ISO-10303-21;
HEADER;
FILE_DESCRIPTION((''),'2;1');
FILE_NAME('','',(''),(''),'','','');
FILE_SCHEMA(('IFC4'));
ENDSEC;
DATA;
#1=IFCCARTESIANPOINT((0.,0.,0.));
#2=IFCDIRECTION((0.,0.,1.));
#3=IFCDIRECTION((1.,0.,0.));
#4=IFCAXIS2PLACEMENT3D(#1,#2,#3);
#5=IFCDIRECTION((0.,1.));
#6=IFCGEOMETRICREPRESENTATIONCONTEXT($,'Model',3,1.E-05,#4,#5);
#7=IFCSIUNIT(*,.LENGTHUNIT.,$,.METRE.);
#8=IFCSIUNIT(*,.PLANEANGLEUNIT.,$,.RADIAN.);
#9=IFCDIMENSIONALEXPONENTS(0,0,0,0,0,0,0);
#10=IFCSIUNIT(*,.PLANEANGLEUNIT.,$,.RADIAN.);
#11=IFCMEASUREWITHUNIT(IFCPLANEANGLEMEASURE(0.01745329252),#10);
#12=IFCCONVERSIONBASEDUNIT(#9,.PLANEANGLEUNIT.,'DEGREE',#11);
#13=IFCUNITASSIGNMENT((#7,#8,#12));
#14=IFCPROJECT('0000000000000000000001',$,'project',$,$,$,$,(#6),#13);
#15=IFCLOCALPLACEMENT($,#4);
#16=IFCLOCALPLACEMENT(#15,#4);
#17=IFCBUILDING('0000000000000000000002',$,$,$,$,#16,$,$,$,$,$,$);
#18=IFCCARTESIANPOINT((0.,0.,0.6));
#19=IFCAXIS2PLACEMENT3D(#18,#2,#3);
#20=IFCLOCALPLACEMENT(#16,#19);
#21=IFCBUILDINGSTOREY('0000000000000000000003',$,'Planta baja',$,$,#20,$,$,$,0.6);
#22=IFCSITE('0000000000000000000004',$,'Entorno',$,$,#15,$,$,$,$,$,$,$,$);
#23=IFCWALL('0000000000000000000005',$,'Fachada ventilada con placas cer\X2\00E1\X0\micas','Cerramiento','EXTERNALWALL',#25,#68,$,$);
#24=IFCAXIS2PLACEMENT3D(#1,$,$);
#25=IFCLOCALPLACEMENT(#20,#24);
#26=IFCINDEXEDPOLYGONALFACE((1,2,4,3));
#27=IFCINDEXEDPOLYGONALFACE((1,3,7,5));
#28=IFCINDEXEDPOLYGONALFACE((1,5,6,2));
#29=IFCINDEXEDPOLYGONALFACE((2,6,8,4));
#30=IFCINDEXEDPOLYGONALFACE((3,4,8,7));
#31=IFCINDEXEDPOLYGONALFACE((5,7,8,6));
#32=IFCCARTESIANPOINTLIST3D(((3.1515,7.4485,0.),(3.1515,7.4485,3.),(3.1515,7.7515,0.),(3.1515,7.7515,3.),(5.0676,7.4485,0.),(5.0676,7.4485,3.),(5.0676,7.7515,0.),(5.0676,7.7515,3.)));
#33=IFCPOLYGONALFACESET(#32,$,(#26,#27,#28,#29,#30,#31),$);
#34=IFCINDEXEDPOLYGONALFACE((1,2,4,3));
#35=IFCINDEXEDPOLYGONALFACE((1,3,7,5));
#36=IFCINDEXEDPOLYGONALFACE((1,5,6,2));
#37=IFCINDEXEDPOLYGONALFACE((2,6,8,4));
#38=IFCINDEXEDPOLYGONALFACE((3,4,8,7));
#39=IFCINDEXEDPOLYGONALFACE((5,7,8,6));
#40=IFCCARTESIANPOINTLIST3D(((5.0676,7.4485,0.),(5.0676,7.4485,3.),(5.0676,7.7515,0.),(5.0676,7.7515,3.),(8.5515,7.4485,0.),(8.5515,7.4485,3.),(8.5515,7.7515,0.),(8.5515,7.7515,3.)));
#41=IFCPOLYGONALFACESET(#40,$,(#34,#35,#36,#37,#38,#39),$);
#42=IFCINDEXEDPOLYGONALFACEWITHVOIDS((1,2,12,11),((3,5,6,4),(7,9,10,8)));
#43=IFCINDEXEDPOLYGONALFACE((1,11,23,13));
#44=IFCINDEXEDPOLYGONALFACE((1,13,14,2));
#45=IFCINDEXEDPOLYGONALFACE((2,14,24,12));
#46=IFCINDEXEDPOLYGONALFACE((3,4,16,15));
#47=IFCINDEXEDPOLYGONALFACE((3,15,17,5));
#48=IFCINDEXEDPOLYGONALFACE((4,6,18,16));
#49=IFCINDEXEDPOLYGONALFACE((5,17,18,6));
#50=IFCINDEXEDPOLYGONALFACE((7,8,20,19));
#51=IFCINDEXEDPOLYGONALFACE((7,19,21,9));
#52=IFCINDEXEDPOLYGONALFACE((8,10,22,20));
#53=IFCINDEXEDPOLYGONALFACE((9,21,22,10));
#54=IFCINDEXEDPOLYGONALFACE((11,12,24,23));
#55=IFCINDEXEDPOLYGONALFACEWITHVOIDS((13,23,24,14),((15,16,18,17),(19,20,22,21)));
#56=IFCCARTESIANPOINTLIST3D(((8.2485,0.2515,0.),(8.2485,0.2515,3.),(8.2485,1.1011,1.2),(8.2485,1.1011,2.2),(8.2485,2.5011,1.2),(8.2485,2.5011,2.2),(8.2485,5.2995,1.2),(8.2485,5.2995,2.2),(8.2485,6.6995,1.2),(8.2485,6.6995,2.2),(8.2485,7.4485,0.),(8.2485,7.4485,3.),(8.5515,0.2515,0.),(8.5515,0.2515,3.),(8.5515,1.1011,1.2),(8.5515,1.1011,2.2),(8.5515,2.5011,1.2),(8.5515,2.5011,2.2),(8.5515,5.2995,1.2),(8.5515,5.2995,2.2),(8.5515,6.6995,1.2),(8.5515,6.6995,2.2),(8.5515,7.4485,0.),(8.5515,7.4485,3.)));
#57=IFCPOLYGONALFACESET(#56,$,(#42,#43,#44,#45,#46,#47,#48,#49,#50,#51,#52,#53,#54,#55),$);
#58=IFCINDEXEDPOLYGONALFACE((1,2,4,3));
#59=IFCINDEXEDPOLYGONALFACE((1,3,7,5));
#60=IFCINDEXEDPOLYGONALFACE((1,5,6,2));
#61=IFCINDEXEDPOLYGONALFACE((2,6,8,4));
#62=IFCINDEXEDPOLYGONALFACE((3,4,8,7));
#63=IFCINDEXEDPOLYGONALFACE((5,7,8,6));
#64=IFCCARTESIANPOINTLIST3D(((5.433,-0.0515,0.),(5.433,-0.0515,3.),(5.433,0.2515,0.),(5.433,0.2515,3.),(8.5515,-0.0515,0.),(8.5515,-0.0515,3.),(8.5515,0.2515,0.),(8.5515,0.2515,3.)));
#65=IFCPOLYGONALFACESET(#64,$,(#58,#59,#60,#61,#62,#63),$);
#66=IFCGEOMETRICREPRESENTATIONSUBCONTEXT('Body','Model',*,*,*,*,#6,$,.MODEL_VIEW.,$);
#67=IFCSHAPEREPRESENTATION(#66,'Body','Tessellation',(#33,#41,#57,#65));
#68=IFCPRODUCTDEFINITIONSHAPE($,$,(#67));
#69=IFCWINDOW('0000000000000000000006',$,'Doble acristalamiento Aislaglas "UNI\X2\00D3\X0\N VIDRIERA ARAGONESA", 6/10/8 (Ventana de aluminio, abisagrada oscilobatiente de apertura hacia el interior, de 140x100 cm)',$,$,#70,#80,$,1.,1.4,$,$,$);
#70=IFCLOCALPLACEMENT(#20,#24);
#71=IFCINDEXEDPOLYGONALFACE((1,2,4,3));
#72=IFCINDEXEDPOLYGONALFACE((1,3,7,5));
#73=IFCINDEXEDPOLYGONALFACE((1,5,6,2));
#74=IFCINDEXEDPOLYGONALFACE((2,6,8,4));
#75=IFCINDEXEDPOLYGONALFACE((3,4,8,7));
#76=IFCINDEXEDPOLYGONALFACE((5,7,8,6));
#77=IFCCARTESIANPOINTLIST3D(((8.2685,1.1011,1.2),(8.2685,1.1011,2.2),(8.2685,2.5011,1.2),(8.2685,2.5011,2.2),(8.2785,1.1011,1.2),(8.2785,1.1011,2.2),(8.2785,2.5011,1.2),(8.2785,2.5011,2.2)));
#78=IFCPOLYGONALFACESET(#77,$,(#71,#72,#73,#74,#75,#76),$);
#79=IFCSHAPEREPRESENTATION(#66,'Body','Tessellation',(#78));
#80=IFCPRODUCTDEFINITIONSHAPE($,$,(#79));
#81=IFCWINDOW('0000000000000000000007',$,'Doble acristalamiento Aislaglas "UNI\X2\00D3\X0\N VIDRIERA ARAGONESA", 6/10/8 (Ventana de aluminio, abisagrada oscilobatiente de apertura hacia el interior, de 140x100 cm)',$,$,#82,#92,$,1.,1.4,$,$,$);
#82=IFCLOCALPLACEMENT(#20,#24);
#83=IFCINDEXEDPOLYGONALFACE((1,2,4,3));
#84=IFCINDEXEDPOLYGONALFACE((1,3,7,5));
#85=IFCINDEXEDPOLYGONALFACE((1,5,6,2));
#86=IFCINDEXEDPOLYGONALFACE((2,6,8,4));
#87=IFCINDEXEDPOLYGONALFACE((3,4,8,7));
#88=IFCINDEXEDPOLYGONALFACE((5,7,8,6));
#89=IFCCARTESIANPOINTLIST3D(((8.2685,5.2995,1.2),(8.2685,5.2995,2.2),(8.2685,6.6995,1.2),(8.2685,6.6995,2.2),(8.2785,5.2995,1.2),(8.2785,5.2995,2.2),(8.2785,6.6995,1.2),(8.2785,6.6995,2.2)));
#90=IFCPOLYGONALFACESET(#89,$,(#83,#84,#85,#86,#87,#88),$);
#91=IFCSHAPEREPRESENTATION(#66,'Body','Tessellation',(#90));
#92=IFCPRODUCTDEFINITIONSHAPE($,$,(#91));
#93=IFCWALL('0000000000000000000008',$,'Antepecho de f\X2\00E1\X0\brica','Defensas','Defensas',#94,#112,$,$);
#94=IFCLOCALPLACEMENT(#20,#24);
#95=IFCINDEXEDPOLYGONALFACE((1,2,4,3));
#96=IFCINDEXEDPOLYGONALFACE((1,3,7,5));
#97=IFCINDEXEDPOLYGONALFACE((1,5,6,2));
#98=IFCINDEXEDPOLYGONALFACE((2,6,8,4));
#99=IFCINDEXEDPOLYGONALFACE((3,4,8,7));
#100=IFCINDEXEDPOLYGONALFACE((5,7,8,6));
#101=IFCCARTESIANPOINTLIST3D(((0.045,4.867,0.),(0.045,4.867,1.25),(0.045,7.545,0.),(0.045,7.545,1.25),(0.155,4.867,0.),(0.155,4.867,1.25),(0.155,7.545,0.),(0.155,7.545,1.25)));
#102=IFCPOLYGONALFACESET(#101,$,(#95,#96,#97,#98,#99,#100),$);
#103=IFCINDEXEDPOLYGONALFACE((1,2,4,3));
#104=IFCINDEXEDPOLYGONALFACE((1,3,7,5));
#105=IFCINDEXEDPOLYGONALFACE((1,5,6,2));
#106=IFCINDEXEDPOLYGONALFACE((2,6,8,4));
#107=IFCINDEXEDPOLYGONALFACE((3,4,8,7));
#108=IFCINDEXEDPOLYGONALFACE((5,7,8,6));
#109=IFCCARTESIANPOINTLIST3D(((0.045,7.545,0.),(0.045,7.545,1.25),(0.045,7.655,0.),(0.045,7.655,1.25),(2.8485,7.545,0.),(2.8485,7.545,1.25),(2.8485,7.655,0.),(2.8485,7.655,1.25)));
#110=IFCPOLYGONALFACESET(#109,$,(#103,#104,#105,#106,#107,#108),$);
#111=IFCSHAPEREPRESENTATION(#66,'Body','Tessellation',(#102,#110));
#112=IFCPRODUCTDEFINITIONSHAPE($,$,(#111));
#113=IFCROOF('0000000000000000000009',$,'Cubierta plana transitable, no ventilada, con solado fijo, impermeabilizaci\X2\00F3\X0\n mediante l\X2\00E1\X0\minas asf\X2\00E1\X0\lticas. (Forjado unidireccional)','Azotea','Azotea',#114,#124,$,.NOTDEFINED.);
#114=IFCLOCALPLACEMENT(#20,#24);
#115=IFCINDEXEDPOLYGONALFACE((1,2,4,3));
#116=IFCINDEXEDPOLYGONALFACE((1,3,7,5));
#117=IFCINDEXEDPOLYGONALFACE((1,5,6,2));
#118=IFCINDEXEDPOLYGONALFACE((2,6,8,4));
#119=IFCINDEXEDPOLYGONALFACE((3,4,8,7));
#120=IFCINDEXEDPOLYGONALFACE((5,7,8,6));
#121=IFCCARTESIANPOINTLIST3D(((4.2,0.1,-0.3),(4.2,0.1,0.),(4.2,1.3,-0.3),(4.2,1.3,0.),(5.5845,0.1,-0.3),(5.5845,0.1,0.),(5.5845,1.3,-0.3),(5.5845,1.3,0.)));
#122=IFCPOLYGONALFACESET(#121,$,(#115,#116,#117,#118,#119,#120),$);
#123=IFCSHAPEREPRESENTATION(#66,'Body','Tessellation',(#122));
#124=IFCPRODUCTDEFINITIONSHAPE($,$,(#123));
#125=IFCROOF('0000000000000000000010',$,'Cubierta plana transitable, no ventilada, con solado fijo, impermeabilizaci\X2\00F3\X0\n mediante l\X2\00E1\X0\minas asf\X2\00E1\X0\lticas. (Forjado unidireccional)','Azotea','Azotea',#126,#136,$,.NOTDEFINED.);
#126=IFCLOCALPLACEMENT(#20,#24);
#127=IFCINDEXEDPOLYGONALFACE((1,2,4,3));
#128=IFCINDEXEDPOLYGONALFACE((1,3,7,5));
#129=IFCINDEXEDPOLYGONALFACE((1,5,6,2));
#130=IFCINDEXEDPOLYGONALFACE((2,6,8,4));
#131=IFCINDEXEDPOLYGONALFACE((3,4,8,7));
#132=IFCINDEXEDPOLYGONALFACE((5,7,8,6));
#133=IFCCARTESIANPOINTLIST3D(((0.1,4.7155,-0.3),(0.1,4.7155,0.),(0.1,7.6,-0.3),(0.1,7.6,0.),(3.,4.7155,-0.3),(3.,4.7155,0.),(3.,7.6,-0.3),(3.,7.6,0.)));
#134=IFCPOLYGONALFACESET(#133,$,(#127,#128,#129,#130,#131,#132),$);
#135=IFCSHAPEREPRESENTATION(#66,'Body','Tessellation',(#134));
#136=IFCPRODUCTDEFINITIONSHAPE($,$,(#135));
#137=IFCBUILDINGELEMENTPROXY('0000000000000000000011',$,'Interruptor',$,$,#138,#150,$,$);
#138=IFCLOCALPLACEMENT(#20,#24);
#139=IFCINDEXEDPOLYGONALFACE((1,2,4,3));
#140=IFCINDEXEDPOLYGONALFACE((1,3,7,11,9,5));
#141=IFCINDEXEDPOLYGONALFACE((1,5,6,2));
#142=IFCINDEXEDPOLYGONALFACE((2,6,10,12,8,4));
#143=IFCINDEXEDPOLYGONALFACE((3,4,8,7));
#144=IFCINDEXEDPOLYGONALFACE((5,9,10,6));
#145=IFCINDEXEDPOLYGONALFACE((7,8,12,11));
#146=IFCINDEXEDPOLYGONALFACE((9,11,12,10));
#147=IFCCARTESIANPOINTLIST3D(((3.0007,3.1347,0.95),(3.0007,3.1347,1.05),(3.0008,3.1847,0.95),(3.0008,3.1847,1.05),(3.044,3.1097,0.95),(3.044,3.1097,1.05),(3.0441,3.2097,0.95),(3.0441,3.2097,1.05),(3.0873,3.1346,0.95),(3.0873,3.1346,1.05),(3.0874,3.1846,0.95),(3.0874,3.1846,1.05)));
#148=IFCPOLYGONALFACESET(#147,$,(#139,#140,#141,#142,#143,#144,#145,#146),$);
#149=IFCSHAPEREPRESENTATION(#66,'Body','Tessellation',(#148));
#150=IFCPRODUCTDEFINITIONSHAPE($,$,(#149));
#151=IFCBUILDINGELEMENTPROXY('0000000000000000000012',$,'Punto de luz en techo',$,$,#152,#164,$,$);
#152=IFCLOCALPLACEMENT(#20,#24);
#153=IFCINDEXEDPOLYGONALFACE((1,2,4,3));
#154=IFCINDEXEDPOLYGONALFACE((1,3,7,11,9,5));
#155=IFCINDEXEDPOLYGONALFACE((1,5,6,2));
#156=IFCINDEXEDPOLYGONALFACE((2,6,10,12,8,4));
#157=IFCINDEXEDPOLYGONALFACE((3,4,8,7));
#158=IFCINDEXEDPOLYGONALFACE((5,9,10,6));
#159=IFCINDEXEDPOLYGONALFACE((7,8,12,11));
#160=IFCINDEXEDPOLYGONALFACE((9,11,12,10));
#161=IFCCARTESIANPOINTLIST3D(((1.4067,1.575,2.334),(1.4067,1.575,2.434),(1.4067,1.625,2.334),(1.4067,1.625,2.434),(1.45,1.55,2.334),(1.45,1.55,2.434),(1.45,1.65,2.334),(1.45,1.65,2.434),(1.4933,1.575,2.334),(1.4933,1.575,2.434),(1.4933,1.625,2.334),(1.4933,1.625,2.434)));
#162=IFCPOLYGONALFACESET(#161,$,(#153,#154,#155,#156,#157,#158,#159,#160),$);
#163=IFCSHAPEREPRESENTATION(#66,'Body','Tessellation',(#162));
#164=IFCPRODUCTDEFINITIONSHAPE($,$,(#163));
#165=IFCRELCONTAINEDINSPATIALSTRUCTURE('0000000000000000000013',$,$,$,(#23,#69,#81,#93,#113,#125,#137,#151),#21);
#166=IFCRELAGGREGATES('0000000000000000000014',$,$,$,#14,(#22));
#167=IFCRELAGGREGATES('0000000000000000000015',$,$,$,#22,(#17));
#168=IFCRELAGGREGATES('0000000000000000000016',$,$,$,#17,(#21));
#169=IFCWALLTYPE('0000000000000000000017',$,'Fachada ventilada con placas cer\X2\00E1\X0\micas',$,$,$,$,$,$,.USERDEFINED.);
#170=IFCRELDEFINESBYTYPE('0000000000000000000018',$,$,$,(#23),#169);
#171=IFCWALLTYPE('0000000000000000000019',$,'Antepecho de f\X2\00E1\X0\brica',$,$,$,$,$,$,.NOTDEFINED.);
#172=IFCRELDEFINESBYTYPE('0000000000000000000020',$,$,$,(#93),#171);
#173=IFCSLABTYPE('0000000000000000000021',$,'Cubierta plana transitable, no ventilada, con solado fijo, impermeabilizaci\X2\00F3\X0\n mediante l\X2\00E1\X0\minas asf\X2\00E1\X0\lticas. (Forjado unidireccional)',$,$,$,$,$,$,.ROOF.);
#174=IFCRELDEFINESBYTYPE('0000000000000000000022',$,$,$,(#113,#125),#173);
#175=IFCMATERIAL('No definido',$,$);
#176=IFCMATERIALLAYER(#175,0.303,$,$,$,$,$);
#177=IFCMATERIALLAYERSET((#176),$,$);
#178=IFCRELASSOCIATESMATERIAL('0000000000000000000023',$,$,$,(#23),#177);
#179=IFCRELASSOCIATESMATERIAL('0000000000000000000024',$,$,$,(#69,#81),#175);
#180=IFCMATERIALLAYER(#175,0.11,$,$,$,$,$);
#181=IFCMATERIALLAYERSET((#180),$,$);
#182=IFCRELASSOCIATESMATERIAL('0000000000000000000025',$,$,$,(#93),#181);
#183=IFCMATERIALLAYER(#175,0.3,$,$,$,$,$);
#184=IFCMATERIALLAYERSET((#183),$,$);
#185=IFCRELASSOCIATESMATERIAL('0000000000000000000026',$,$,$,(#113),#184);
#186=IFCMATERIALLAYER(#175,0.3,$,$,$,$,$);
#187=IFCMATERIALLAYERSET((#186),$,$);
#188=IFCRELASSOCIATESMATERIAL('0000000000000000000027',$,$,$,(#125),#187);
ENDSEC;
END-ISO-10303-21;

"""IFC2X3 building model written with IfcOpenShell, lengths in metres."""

from ifc_helpers import new_model, entity, si_unit, converted_unit, direction, frame, origin_with_axes, origin_2d_with_axis, place, context, subcontext, project, spatial, polyline, rectangle, outline, extrude, shape, source, transform, mapped, material, layer, layer_set, layer_usage, type_object, element, fill, save


model = new_model("IFC2X3")

# Units and contexts
model_context = context("Model", 3, precision=1e-05, world=origin_with_axes(), true_north=direction((0.0, 1.0)))
body_context = subcontext(model_context, "Body", "Model", "MODEL_VIEW")
footprint_context = subcontext(model_context, "FootPrint", "Model", "MODEL_VIEW")
ifc_project = project(units=[si_unit("LENGTHUNIT", "METRE"), si_unit("PLANEANGLEUNIT", "RADIAN"), converted_unit("PLANEANGLEUNIT", "DEGREE", entity("IfcPlaneAngleMeasure", 0.01745329252), si_unit("PLANEANGLEUNIT", "RADIAN"), dimensions=[0, 0, 0, 0, 0, 0, 0])], contexts=[model_context])

# Site, building, storey
site_placement = place(None, origin_with_axes())
site = spatial("IfcSite", under=ifc_project, at=site_placement, Name="Entorno")
building_placement = place(site_placement, origin_with_axes())
building = spatial("IfcBuilding", under=site, at=building_placement)
storey_placement = place(building_placement, frame((0.0, 0.0, 0.6), z_axis=(0.0, 0.0, 1.0), x_axis=(1.0, 0.0, 0.0)))
storey = spatial("IfcBuildingStorey", under=building, at=storey_placement, Name="Planta baja", Elevation=0.6)

# Shared definitions
ifc_material = material(Name="No definido")

# Shared definitions
wall_type_1 = type_object("IfcWallType", Name="Fachada ventilada con placas cerámicas", PredefinedType="USERDEFINED")

# Wall, openings, windows
ifc_layer_1 = layer(ifc_material, 0.303)
ifc_layer_set_1 = layer_set([ifc_layer_1])
ifc_layer_usage_1 = layer_usage(ifc_layer_set_1, "AXIS2", "POSITIVE", -0.1515)
wall_1_placement = place(storey_placement, frame((3.0, 7.6, 0.0), z_axis=(0.0, 0.0, 1.0), x_axis=(1.0, 0.0, 0.0)))
wall_1 = element("IfcWall", 1, at=wall_1_placement, inside=storey, type_object=wall_type_1, material=ifc_layer_usage_1, Name="Fachada ventilada con placas cerámicas", Description="Cerramiento", ObjectType="EXTERNALWALL", context=body_context, shape_type="SolidModel", body=[
    extrude(outline(polyline([(-0.958, -1.5), (0.958, -1.5), (0.958, 1.5), (-0.958, 1.5), (-0.958, -1.5)])), frame((1.1096, 0.1515, 1.5), z_axis=(0.0, -1.0, 0.0), x_axis=(1.0, 0.0, 0.0)), (0.0, 0.0, 1.0), 0.303),
    extrude(outline(polyline([(-1.742, -1.5), (1.742, -1.5), (1.742, 1.5), (-1.742, 1.5), (-1.742, -1.5)])), frame((3.8096, 0.1515, 1.5), z_axis=(0.0, -1.0, 0.0), x_axis=(1.0, 0.0, 0.0)), (0.0, 0.0, 1.0), 0.303),
    extrude(outline(polyline([(-3.5985, -1.5), (3.5985, -1.5), (3.5985, 1.5), (-3.5985, 1.5), (-3.5985, -1.5)])), frame((5.5515, -3.75, 1.5), z_axis=(-1.0, 0.0, 0.0), x_axis=(0.0, -1.0, 0.0)), (0.0, 0.0, 1.0), 0.303),
    extrude(outline(polyline([(-1.5593, -1.5), (1.5593, -1.5), (1.5593, 1.5), (-1.5593, 1.5), (-1.5593, -1.5)])), frame((3.9922, -7.6515, 1.5), z_axis=(0.0, 1.0, 0.0), x_axis=(-1.0, 0.0, 0.0)), (0.0, 0.0, 1.0), 0.303),
])
opening_1_placement = place(wall_1_placement, frame((5.4, -5.7989, 1.7), z_axis=(0.0, 0.0, 1.0), x_axis=(0.0, -1.0, 0.0)))
cartesian_point_1 = entity("IfcCartesianPoint", [-0.7, -0.1515])
opening_1 = element("IfcOpeningElement", 2, at=opening_1_placement, cuts=wall_1, ObjectType="No definido", shapes=[
    shape(body_context, "Body", "SweptSolid", [extrude(rectangle(XDim=1.0, YDim=1.4, at=origin_2d_with_axis()), frame((0.0, -0.1515, 0.0), z_axis=(0.0, 1.0, 0.0), x_axis=(0.0, 0.0, 1.0)), (0.0, 0.0, 1.0), 0.303)]),
    shape(footprint_context, "FootPrint", "GeometricCurveSet", [entity("IfcGeometricCurveSet", [entity("IfcPolyline", [cartesian_point_1, entity("IfcCartesianPoint", [0.7, -0.1515]), entity("IfcCartesianPoint", [0.7, 0.1515]), entity("IfcCartesianPoint", [-0.7, 0.1515]), cartesian_point_1])])]),
])
opening_2_placement = place(wall_1_placement, frame((5.4, -1.6005, 1.7), z_axis=(0.0, 0.0, 1.0), x_axis=(0.0, -1.0, 0.0)))
cartesian_point_2 = entity("IfcCartesianPoint", [-0.7, -0.1515])
opening_2 = element("IfcOpeningElement", 3, at=opening_2_placement, cuts=wall_1, ObjectType="No definido", shapes=[
    shape(body_context, "Body", "SweptSolid", [extrude(rectangle(XDim=1.0, YDim=1.4, at=origin_2d_with_axis()), frame((0.0, -0.1515, 0.0), z_axis=(0.0, 1.0, 0.0), x_axis=(0.0, 0.0, 1.0)), (0.0, 0.0, 1.0), 0.303)]),
    shape(footprint_context, "FootPrint", "GeometricCurveSet", [entity("IfcGeometricCurveSet", [entity("IfcPolyline", [cartesian_point_2, entity("IfcCartesianPoint", [0.7, -0.1515]), entity("IfcCartesianPoint", [0.7, 0.1515]), entity("IfcCartesianPoint", [-0.7, 0.1515]), cartesian_point_2])])]),
])
window_1_placement = place(opening_1_placement, frame((0.0, -0.1265, 0.0), z_axis=(0.0, 0.0, 1.0), x_axis=(1.0, 0.0, 0.0)))
window_1 = element("IfcWindow", 4, at=window_1_placement, inside=storey, material=ifc_material, Name="Doble acristalamiento Aislaglas \"UNIÓN VIDRIERA ARAGONESA\", 6/10/8 (Ventana de aluminio, abisagrada oscilobatiente de apertura hacia el interior, de 140x100 cm)", OverallHeight=1.0, OverallWidth=1.4, context=body_context, shape_type="SweptSolid", body=[
    extrude(rectangle(XDim=1.4, YDim=1.0, at=origin_2d_with_axis()), frame((0.0, 0.005, 0.0), z_axis=(0.0, -1.0, 0.0), x_axis=(1.0, 0.0, 0.0)), (0.0, 0.0, 1.0), 0.01),
])
fill(opening_1, window_1)
window_2_placement = place(opening_2_placement, frame((0.0, -0.1265, 0.0), z_axis=(0.0, 0.0, 1.0), x_axis=(1.0, 0.0, 0.0)))
window_2 = element("IfcWindow", 5, at=window_2_placement, inside=storey, material=ifc_material, Name="Doble acristalamiento Aislaglas \"UNIÓN VIDRIERA ARAGONESA\", 6/10/8 (Ventana de aluminio, abisagrada oscilobatiente de apertura hacia el interior, de 140x100 cm)", OverallHeight=1.0, OverallWidth=1.4, context=body_context, shape_type="SweptSolid", body=[
    extrude(rectangle(XDim=1.4, YDim=1.0, at=origin_2d_with_axis()), frame((0.0, 0.005, 0.0), z_axis=(0.0, -1.0, 0.0), x_axis=(1.0, 0.0, 0.0)), (0.0, 0.0, 1.0), 0.01),
])
fill(opening_2, window_2)

# Wall
ifc_layer_2 = layer(ifc_material, 0.11)
ifc_layer_set_2 = layer_set([ifc_layer_2])
ifc_layer_usage_2 = layer_usage(ifc_layer_set_2, "AXIS2", "POSITIVE", -0.055)
wall_type_2 = type_object("IfcWallType", Name="Antepecho de fábrica")
wall_2_placement = place(storey_placement, frame((0.1, 4.848, 0.0), z_axis=(0.0, 0.0, 1.0), x_axis=(0.0, 1.0, 0.0)))
element("IfcWall", 6, at=wall_2_placement, inside=storey, type_object=wall_type_2, material=ifc_layer_usage_2, Name="Antepecho de fábrica", Description="Defensas", ObjectType="Defensas", context=body_context, shape_type="SolidModel", body=[
    extrude(outline(polyline([(-1.339, -0.625), (1.339, -0.625), (1.339, 0.625), (-1.339, 0.625), (-1.339, -0.625)])), frame((1.358, 0.055, 0.625), z_axis=(0.0, -1.0, 0.0), x_axis=(1.0, 0.0, 0.0)), (0.0, 0.0, 1.0), 0.11),
    extrude(outline(polyline([(-1.4018, -0.625), (1.4018, -0.625), (1.4018, 0.625), (-1.4018, 0.625), (-1.4018, -0.625)])), frame((2.807, -1.3467, 0.625), z_axis=(-1.0, 0.0, 0.0), x_axis=(0.0, -1.0, 0.0)), (0.0, 0.0, 1.0), 0.11),
])

# Roofs
ifc_layer_3 = layer(ifc_material, 0.3)
ifc_layer_set_3 = layer_set([ifc_layer_3])
ifc_layer_usage_3 = layer_usage(ifc_layer_set_3, "AXIS3", "POSITIVE", 0.0)
slab_type_1 = type_object("IfcSlabType", Name="Cubierta plana transitable, no ventilada, con solado fijo, impermeabilización mediante láminas asfálticas. (Forjado unidireccional)", PredefinedType="ROOF")
roof_1_placement = place(storey_placement, frame((5.5845, 0.1, -0.3), z_axis=(0.0, 0.0, 1.0), x_axis=(1.0, 0.0, 0.0)))
element("IfcRoof", 7, at=roof_1_placement, inside=storey, type_object=slab_type_1, material=ifc_layer_usage_3, Name="Cubierta plana transitable, no ventilada, con solado fijo, impermeabilización mediante láminas asfálticas. (Forjado unidireccional)", Description="Azotea", ObjectType="Azotea", ShapeType="NOTDEFINED", context=body_context, shape_type="SweptSolid", body=[
    extrude(outline(polyline([(0.0, 0.0), (0.0, 1.2), (-1.3845, 1.2), (-1.3845, 0.0), (0.0, 0.0)])), origin_with_axes(), (0.0, 0.0, 1.0), 0.3),
])
ifc_layer_4 = layer(ifc_material, 0.3)
ifc_layer_set_4 = layer_set([ifc_layer_4])
ifc_layer_usage_4 = layer_usage(ifc_layer_set_4, "AXIS3", "POSITIVE", 0.0)
roof_2_placement = place(storey_placement, frame((0.1, 7.6, -0.3), z_axis=(0.0, 0.0, 1.0), x_axis=(1.0, 0.0, 0.0)))
element("IfcRoof", 8, at=roof_2_placement, inside=storey, type_object=slab_type_1, material=ifc_layer_usage_4, Name="Cubierta plana transitable, no ventilada, con solado fijo, impermeabilización mediante láminas asfálticas. (Forjado unidireccional)", Description="Azotea", ObjectType="Azotea", ShapeType="NOTDEFINED", context=body_context, shape_type="SweptSolid", body=[
    extrude(outline(polyline([(0.0, 0.0), (0.0, -2.8845), (2.9, -2.8845), (2.9, 0.0), (0.0, 0.0)])), origin_with_axes(), (0.0, 0.0, 1.0), 0.3),
])

# Building element proxies
shared_shape_1 = source(origin_with_axes(), body_context, "Body", "SolidModel", [
    extrude(outline(polyline([(0.05, 0.0), (0.025, 0.0433), (-0.025, 0.0433), (-0.05, 0.0), (-0.025, -0.0433), (0.025, -0.0433), (0.05, 0.0)])), frame((0.0, 0.0, -0.05), z_axis=(0.0, 0.0, 1.0), x_axis=(1.0, 0.0, 0.0)), (0.0, 0.0, 1.0), 0.1),
])
proxy_1_placement = place(storey_placement, frame((0.0, 0.0, -0.6), z_axis=(0.0, 0.0, 1.0), x_axis=(1.0, 0.0, 0.0)))
element("IfcBuildingElementProxy", 9, at=proxy_1_placement, inside=storey, Name="Interruptor", context=body_context, shape_type="Brep", body=[
    mapped(shared_shape_1, transform((3.0441, 3.1597, 1.6), x_axis=(-0.001016, -0.999999, 0.0), y_axis=(0.999999, -0.001016, 0.0), z_axis=(0.0, 0.0, 1.0))),
])
shared_shape_2 = source(origin_with_axes(), body_context, "Body", "SolidModel", [
    extrude(outline(polyline([(0.05, 0.0), (0.025, 0.0433), (-0.025, 0.0433), (-0.05, 0.0), (-0.025, -0.0433), (0.025, -0.0433), (0.05, 0.0)])), frame((0.0, 0.0, -0.05), z_axis=(0.0, 0.0, 1.0), x_axis=(1.0, 0.0, 0.0)), (0.0, 0.0, 1.0), 0.1),
])
proxy_2_placement = place(storey_placement, frame((0.0, 0.0, -0.6), z_axis=(0.0, 0.0, 1.0), x_axis=(1.0, 0.0, 0.0)))
element("IfcBuildingElementProxy", 10, at=proxy_2_placement, inside=storey, Name="Punto de luz en techo", context=body_context, shape_type="Brep", body=[
    mapped(shared_shape_2, transform((1.45, 1.6, 2.984), x_axis=(0.0, -1.0, 0.0), y_axis=(1.0, 0.0, 0.0), z_axis=(0.0, 0.0, 1.0))),
])

save(model, "model.ifc")
